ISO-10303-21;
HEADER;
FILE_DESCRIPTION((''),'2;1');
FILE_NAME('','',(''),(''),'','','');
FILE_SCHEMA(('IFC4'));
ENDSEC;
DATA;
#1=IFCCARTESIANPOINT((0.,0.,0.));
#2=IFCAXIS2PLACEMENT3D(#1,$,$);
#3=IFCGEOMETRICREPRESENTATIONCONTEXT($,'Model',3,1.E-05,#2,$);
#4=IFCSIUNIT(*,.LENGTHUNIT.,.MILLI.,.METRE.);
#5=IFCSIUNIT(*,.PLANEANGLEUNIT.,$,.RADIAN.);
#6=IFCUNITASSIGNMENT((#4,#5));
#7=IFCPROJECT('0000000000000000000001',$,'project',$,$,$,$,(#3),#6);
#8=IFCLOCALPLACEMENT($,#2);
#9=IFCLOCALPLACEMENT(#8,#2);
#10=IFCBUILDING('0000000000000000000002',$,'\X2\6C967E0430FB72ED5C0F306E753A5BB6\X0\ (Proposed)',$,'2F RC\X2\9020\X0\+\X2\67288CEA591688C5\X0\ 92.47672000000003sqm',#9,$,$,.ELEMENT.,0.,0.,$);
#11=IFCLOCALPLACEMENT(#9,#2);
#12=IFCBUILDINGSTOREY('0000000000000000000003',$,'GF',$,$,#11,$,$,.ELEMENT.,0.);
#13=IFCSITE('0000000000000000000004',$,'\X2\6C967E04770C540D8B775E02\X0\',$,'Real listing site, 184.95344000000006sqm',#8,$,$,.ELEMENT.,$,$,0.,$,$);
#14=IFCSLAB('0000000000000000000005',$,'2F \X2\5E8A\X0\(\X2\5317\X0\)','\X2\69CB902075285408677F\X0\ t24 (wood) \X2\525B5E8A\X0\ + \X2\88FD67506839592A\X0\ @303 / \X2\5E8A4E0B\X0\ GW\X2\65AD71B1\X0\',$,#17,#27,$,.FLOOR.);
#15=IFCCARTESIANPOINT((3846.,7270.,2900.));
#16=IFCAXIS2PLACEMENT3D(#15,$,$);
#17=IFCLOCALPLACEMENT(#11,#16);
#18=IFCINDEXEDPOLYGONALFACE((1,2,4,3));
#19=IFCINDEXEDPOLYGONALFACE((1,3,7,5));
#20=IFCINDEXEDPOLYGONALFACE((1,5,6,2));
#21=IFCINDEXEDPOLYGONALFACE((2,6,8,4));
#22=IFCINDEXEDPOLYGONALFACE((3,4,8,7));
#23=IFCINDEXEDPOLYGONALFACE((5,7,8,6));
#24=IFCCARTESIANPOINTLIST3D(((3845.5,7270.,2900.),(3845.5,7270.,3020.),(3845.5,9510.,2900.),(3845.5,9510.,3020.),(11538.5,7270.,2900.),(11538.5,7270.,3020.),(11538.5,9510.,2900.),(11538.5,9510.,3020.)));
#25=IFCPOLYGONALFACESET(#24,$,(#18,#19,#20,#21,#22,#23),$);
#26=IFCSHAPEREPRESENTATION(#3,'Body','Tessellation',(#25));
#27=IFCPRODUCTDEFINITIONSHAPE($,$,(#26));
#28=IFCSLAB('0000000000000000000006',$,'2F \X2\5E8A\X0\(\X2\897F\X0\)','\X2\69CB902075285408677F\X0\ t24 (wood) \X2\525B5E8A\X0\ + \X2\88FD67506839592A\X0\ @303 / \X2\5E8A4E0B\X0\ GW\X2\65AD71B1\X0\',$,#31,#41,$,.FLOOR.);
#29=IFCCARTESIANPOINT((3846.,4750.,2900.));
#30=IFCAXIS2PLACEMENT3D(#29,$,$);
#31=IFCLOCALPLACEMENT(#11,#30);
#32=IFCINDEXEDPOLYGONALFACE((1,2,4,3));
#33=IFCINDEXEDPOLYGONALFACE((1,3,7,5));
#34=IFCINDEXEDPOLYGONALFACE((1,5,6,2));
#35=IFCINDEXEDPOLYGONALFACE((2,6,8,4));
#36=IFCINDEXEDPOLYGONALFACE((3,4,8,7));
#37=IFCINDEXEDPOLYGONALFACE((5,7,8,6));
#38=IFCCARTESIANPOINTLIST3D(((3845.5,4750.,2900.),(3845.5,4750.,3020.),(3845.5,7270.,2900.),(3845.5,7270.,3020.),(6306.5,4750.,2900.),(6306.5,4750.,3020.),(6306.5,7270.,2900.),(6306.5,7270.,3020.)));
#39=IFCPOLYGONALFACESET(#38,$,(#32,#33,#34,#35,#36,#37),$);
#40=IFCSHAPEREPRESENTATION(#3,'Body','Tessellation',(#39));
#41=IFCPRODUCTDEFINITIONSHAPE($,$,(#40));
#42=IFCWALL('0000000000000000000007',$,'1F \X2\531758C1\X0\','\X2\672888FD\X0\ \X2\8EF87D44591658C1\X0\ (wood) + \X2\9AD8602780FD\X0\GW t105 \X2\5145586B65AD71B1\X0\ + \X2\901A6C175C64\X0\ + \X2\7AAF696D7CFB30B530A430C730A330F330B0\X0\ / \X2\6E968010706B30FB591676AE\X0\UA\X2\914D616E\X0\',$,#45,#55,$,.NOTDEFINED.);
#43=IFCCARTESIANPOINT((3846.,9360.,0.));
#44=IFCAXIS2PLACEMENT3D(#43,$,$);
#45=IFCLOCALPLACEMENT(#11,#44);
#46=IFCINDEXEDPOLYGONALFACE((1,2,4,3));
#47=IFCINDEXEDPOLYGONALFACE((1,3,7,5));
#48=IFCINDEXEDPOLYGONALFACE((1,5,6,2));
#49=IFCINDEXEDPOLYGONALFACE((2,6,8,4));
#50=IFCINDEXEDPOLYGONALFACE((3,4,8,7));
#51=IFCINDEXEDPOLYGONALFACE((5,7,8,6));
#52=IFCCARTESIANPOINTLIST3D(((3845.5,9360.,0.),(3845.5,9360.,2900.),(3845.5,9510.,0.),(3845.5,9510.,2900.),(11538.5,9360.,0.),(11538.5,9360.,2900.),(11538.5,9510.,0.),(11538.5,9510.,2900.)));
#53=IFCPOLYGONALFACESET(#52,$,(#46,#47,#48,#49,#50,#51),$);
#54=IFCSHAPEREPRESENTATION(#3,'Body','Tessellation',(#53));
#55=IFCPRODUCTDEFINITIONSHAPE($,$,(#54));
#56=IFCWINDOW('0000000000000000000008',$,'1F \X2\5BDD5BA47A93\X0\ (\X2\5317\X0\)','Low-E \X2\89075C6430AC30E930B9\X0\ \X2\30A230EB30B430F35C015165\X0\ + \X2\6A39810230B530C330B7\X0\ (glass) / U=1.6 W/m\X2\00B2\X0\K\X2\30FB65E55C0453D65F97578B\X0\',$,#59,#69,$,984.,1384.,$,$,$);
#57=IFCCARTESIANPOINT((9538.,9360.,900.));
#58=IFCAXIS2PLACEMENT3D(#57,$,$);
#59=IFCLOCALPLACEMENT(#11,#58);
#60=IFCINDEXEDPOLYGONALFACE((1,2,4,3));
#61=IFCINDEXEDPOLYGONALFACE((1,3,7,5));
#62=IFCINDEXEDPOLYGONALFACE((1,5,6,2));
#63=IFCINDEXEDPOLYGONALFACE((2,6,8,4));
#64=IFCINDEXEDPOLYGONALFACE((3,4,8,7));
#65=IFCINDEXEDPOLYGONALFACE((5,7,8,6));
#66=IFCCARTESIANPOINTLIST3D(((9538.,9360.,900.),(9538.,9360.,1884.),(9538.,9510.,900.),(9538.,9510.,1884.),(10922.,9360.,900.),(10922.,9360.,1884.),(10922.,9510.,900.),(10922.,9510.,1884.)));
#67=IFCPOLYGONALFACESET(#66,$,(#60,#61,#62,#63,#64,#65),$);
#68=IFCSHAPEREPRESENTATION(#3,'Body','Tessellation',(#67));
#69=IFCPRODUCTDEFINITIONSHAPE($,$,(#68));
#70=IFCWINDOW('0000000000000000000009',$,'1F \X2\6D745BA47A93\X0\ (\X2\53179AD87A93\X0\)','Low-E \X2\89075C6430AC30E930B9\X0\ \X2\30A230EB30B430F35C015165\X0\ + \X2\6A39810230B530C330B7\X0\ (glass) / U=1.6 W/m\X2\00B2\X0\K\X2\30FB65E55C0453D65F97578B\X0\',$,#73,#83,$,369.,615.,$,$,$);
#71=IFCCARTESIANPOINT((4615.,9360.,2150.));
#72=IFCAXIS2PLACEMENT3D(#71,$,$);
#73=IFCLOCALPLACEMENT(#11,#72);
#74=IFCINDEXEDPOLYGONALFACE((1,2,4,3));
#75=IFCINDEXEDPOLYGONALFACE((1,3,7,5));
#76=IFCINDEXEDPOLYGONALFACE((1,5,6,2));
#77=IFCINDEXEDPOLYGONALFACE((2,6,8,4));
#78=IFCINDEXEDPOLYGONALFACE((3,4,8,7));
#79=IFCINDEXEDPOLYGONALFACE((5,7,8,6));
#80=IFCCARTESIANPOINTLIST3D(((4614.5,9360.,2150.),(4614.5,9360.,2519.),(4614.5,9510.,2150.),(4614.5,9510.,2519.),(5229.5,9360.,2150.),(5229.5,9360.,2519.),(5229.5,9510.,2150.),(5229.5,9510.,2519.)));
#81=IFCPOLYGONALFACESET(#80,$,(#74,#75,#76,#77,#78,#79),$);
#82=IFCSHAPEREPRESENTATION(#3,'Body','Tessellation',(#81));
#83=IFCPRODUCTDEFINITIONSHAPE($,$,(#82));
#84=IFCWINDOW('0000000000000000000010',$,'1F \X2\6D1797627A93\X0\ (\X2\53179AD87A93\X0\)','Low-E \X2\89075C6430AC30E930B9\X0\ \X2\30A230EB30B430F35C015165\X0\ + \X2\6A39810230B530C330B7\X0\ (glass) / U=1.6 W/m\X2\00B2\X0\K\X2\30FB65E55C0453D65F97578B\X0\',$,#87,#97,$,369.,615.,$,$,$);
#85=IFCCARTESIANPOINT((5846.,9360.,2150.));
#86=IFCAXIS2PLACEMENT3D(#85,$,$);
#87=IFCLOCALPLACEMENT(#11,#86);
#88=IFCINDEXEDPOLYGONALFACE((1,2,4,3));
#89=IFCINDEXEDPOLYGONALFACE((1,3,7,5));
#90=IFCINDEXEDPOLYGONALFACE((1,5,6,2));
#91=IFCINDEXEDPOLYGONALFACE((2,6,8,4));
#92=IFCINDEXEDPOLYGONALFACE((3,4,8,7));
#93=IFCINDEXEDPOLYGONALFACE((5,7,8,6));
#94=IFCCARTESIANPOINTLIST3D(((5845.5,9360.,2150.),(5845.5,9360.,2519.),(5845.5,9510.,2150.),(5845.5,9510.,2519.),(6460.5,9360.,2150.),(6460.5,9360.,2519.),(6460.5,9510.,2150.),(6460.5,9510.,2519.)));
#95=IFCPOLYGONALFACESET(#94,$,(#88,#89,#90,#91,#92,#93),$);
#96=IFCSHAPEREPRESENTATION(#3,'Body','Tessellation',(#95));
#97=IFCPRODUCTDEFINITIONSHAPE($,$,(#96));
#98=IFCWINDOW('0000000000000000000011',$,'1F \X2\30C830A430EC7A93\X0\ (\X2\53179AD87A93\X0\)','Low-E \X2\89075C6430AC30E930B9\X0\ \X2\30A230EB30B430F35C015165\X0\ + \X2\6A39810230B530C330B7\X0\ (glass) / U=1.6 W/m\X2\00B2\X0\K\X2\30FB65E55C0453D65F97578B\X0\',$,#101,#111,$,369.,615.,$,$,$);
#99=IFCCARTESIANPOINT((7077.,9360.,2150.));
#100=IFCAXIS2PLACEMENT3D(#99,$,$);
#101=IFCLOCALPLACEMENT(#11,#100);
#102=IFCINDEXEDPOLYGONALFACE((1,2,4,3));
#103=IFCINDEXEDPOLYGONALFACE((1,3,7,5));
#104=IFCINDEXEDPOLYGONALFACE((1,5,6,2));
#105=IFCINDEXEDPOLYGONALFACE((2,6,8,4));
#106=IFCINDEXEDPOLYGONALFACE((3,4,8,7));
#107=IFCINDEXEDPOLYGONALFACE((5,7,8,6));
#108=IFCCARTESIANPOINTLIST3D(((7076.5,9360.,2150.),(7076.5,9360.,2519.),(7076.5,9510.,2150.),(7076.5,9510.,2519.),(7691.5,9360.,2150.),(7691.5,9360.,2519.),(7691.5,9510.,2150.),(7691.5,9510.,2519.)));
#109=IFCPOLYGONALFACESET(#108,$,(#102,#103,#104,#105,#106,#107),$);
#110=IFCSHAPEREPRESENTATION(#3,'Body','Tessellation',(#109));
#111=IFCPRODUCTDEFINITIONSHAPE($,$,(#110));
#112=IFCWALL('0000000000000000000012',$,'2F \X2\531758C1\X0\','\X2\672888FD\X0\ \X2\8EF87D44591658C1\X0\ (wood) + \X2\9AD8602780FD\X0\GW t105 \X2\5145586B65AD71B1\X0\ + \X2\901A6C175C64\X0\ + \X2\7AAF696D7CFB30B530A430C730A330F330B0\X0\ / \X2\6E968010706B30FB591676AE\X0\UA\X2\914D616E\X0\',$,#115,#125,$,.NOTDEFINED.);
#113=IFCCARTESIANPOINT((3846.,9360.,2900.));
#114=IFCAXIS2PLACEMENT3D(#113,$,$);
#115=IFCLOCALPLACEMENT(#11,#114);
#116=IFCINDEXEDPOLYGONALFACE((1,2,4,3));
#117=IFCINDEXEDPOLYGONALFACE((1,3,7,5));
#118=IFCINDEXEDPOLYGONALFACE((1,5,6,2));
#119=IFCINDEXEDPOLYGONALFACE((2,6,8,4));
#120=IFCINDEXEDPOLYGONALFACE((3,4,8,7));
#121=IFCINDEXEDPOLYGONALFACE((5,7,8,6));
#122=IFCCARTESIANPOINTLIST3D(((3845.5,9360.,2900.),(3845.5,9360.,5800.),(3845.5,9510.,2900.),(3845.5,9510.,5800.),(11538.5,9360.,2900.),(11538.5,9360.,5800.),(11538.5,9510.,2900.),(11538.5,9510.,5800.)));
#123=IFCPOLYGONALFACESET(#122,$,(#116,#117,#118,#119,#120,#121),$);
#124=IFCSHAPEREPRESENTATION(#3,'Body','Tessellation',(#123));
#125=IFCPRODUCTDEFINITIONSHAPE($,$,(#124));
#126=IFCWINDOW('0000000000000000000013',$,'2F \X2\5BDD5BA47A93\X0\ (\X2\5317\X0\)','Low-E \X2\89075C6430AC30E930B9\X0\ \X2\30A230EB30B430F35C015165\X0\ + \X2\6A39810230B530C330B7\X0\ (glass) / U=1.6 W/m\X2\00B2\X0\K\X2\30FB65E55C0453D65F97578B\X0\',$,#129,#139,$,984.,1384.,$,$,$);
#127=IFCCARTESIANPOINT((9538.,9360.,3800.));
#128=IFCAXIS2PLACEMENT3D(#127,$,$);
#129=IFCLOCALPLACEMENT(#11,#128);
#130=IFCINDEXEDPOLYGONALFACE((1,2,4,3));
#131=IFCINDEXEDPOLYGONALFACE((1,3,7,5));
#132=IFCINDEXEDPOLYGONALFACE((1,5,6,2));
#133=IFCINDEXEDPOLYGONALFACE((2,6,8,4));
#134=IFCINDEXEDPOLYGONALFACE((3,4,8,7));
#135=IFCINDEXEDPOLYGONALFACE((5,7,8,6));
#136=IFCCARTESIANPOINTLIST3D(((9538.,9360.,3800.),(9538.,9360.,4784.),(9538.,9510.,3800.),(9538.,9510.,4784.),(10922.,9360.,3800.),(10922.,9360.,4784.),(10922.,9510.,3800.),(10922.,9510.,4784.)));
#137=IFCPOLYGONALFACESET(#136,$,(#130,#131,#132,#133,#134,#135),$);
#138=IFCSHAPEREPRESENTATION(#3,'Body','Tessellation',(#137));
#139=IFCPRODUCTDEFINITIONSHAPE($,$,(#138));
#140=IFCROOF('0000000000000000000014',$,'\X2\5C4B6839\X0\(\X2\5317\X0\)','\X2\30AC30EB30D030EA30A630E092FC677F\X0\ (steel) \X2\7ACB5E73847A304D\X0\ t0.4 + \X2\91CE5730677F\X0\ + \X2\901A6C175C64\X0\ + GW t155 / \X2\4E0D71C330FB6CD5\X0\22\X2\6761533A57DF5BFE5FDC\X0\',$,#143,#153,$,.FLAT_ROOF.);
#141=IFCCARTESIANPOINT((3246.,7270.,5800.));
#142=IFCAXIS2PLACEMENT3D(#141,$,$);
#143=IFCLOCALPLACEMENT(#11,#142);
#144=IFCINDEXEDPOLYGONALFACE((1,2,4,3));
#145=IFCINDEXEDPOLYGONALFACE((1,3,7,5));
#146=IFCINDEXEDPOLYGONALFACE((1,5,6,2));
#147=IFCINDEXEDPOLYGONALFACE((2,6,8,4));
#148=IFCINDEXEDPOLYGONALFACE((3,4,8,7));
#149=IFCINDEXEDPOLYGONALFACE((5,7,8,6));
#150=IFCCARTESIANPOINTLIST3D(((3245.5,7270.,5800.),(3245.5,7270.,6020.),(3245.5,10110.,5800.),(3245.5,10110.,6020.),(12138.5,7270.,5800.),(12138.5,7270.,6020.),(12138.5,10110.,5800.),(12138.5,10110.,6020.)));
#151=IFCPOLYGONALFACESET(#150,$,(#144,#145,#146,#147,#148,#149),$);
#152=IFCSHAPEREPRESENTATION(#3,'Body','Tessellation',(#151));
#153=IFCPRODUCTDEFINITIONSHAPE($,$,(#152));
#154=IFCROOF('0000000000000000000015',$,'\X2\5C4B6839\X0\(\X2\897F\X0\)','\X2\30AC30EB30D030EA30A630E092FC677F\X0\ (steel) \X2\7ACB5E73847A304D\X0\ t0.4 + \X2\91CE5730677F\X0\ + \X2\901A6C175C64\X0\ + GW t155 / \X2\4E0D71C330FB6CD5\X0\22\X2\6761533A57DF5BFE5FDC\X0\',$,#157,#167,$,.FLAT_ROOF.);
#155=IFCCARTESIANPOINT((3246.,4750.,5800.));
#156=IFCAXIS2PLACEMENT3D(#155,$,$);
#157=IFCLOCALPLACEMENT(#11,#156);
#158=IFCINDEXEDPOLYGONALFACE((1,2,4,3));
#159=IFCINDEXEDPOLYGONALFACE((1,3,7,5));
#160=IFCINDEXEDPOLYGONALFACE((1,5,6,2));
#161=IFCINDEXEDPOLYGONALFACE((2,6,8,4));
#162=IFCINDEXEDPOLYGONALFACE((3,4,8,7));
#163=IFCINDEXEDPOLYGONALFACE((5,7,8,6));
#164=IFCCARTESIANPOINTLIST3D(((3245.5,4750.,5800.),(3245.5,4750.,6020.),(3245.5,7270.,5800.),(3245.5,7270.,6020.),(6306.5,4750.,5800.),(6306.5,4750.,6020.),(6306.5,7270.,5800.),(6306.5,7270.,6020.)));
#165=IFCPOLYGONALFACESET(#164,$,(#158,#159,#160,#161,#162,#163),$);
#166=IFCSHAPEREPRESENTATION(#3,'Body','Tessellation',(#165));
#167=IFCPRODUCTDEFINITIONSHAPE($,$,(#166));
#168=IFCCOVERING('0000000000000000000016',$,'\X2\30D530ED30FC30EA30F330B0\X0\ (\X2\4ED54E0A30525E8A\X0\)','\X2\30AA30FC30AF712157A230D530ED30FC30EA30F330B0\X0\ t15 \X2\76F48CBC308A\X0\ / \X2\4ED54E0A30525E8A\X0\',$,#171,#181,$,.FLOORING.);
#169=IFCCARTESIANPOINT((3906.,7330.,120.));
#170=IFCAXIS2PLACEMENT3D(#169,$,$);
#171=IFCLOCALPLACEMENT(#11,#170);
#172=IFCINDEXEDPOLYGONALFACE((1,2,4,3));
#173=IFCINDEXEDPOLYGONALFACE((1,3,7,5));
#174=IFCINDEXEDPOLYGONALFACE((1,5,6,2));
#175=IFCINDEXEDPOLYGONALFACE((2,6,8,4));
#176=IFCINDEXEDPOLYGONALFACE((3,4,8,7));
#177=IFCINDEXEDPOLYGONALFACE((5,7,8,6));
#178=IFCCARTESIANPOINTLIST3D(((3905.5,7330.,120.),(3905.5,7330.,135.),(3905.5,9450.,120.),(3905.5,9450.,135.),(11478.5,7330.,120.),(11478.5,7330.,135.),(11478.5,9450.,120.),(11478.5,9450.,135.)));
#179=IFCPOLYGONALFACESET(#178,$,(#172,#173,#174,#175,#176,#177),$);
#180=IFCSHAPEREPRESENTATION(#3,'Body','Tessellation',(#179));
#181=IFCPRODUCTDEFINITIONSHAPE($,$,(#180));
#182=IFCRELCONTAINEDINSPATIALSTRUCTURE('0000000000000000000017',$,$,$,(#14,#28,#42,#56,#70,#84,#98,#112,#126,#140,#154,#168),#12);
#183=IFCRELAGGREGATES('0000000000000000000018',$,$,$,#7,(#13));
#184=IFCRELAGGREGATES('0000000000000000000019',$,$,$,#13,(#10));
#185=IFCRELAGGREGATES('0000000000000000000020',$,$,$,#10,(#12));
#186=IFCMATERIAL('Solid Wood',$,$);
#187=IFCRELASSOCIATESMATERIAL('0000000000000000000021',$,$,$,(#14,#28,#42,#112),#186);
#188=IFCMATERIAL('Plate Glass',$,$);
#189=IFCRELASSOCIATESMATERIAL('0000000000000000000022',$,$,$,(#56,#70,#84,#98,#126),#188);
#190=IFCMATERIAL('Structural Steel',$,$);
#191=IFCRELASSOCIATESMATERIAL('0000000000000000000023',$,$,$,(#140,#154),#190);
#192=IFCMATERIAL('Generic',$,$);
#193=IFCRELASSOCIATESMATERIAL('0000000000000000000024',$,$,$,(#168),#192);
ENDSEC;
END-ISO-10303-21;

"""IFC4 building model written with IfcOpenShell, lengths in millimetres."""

from ifc_helpers import new_model, si_unit, frame, frame_2d, origin, place, context, project, spatial, rectangle, extrude, material, element, fill, save


model = new_model("IFC4")

# Units and contexts
model_context = context("Model", 3, precision=1e-05, world=origin())
ifc_project = project(units=[si_unit("LENGTHUNIT", "METRE", prefix="MILLI"), si_unit("PLANEANGLEUNIT", "RADIAN")], contexts=[model_context])

# Site, building, storey
site_placement = place(None, origin())
site = spatial("IfcSite", under=ifc_project, at=site_placement, Name="沖縄県名護市", ObjectType="Real listing site, 184.95344000000006sqm", CompositionType="ELEMENT", RefElevation=0.0)
building_placement = place(site_placement, origin())
building = spatial("IfcBuilding", under=site, at=building_placement, Name="沖縄・狭小の町家 (Proposed)", ObjectType="2F RC造+木質外装 92.47672000000003sqm", CompositionType="ELEMENT", ElevationOfRefHeight=0.0, ElevationOfTerrain=0.0)
storey_placement = place(building_placement, origin())
storey = spatial("IfcBuildingStorey", under=building, at=storey_placement, Name="GF", CompositionType="ELEMENT", Elevation=0.0)

# Slabs
ifc_material_1 = material(Name="Solid Wood")
slab_1_placement = place(storey_placement, frame((3846.0, 7270.0, 2900.0)))
element("IfcSlab", 1, at=slab_1_placement, inside=storey, material=ifc_material_1, Name="2F 床(北)", Description="構造用合板 t24 (wood) 剛床 + 製材根太 @303 / 床下 GW断熱", PredefinedType="FLOOR", context=model_context, shape_type="SweptSolid", body=[
    extrude(rectangle(XDim=7693.0, YDim=2240.0, at=frame_2d((3846.0, 1120.0))), frame((3846.0, 7270.0, 2900.0)), (0.0, 0.0, 1.0), 120.0),
])
slab_2_placement = place(storey_placement, frame((3846.0, 4750.0, 2900.0)))
element("IfcSlab", 2, at=slab_2_placement, inside=storey, material=ifc_material_1, Name="2F 床(西)", Description="構造用合板 t24 (wood) 剛床 + 製材根太 @303 / 床下 GW断熱", PredefinedType="FLOOR", context=model_context, shape_type="SweptSolid", body=[
    extrude(rectangle(XDim=2461.0, YDim=2520.0, at=frame_2d((1230.0, 1260.0))), frame((3846.0, 4750.0, 2900.0)), (0.0, 0.0, 1.0), 120.0),
])

# Wall, openings, windows
wall_1_placement = place(storey_placement, frame((3846.0, 9360.0, 0.0)))
wall_1 = element("IfcWall", 3, at=wall_1_placement, inside=storey, material=ifc_material_1, Name="1F 北壁", Description="木製 軸組外壁 (wood) + 高性能GW t105 充填断熱 + 通気層 + 窯業系サイディング / 準耐火・外皮UA配慮", PredefinedType="NOTDEFINED", context=model_context, shape_type="SweptSolid", body=[
    extrude(rectangle(XDim=7693.0, YDim=150.0, at=frame_2d((3846.0, 75.0))), frame((3846.0, 9360.0, 0.0)), (0.0, 0.0, 1.0), 2900.0),
])
opening_1_placement = place(storey_placement, frame((9538.0, 9360.0, 900.0)))
opening_1 = element("IfcOpeningElement", 4, at=opening_1_placement, cuts=wall_1, PredefinedType="NOTDEFINED", context=model_context, shape_type="SweptSolid", body=[
    extrude(rectangle(XDim=1384.0, YDim=150.0, at=frame_2d((692.0, 75.0))), frame((9538.0, 9360.0, 900.0)), (0.0, 0.0, 1.0), 984.0),
])
opening_2_placement = place(storey_placement, frame((4615.0, 9360.0, 2150.0)))
opening_2 = element("IfcOpeningElement", 5, at=opening_2_placement, cuts=wall_1, PredefinedType="NOTDEFINED", context=model_context, shape_type="SweptSolid", body=[
    extrude(rectangle(XDim=615.0, YDim=150.0, at=frame_2d((307.0, 75.0))), frame((4615.0, 9360.0, 2150.0)), (0.0, 0.0, 1.0), 369.0),
])
opening_3_placement = place(storey_placement, frame((5846.0, 9360.0, 2150.0)))
opening_3 = element("IfcOpeningElement", 6, at=opening_3_placement, cuts=wall_1, PredefinedType="NOTDEFINED", context=model_context, shape_type="SweptSolid", body=[
    extrude(rectangle(XDim=615.0, YDim=150.0, at=frame_2d((307.0, 75.0))), frame((5846.0, 9360.0, 2150.0)), (0.0, 0.0, 1.0), 369.0),
])
opening_4_placement = place(storey_placement, frame((7077.0, 9360.0, 2150.0)))
opening_4 = element("IfcOpeningElement", 7, at=opening_4_placement, cuts=wall_1, PredefinedType="NOTDEFINED", context=model_context, shape_type="SweptSolid", body=[
    extrude(rectangle(XDim=615.0, YDim=150.0, at=frame_2d((307.0, 75.0))), frame((7077.0, 9360.0, 2150.0)), (0.0, 0.0, 1.0), 369.0),
])
ifc_material_2 = material(Name="Plate Glass")
window_1_placement = place(storey_placement, frame((9538.0, 9360.0, 900.0)))
window_1 = element("IfcWindow", 8, at=window_1_placement, inside=storey, material=ifc_material_2, Name="1F 寝室窓 (北)", Description="Low-E 複層ガラス アルゴン封入 + 樹脂サッシ (glass) / U=1.6 W/m²K・日射取得型", OverallHeight=984.0, OverallWidth=1384.0, context=model_context, shape_type="SweptSolid", body=[
    extrude(rectangle(XDim=1384.0, YDim=150.0, at=frame_2d((692.0, 75.0))), frame((9538.0, 9360.0, 900.0)), (0.0, 0.0, 1.0), 984.0),
])
fill(opening_1, window_1)
window_2_placement = place(storey_placement, frame((4615.0, 9360.0, 2150.0)))
window_2 = element("IfcWindow", 9, at=window_2_placement, inside=storey, material=ifc_material_2, Name="1F 浴室窓 (北高窓)", Description="Low-E 複層ガラス アルゴン封入 + 樹脂サッシ (glass) / U=1.6 W/m²K・日射取得型", OverallHeight=369.0, OverallWidth=615.0, context=model_context, shape_type="SweptSolid", body=[
    extrude(rectangle(XDim=615.0, YDim=150.0, at=frame_2d((307.0, 75.0))), frame((4615.0, 9360.0, 2150.0)), (0.0, 0.0, 1.0), 369.0),
])
fill(opening_2, window_2)
window_3_placement = place(storey_placement, frame((5846.0, 9360.0, 2150.0)))
window_3 = element("IfcWindow", 10, at=window_3_placement, inside=storey, material=ifc_material_2, Name="1F 洗面窓 (北高窓)", Description="Low-E 複層ガラス アルゴン封入 + 樹脂サッシ (glass) / U=1.6 W/m²K・日射取得型", OverallHeight=369.0, OverallWidth=615.0, context=model_context, shape_type="SweptSolid", body=[
    extrude(rectangle(XDim=615.0, YDim=150.0, at=frame_2d((307.0, 75.0))), frame((5846.0, 9360.0, 2150.0)), (0.0, 0.0, 1.0), 369.0),
])
fill(opening_3, window_3)
window_4_placement = place(storey_placement, frame((7077.0, 9360.0, 2150.0)))
window_4 = element("IfcWindow", 11, at=window_4_placement, inside=storey, material=ifc_material_2, Name="1F トイレ窓 (北高窓)", Description="Low-E 複層ガラス アルゴン封入 + 樹脂サッシ (glass) / U=1.6 W/m²K・日射取得型", OverallHeight=369.0, OverallWidth=615.0, context=model_context, shape_type="SweptSolid", body=[
    extrude(rectangle(XDim=615.0, YDim=150.0, at=frame_2d((307.0, 75.0))), frame((7077.0, 9360.0, 2150.0)), (0.0, 0.0, 1.0), 369.0),
])
fill(opening_4, window_4)

# Wall, opening, window
wall_2_placement = place(storey_placement, frame((3846.0, 9360.0, 2900.0)))
wall_2 = element("IfcWall", 12, at=wall_2_placement, inside=storey, material=ifc_material_1, Name="2F 北壁", Description="木製 軸組外壁 (wood) + 高性能GW t105 充填断熱 + 通気層 + 窯業系サイディング / 準耐火・外皮UA配慮", PredefinedType="NOTDEFINED", context=model_context, shape_type="SweptSolid", body=[
    extrude(rectangle(XDim=7693.0, YDim=150.0, at=frame_2d((3846.0, 75.0))), frame((3846.0, 9360.0, 2900.0)), (0.0, 0.0, 1.0), 2900.0),
])
opening_5_placement = place(storey_placement, frame((9538.0, 9360.0, 3800.0)))
opening_5 = element("IfcOpeningElement", 13, at=opening_5_placement, cuts=wall_2, PredefinedType="NOTDEFINED", context=model_context, shape_type="SweptSolid", body=[
    extrude(rectangle(XDim=1384.0, YDim=150.0, at=frame_2d((692.0, 75.0))), frame((9538.0, 9360.0, 3800.0)), (0.0, 0.0, 1.0), 984.0),
])
window_5_placement = place(storey_placement, frame((9538.0, 9360.0, 3800.0)))
window_5 = element("IfcWindow", 14, at=window_5_placement, inside=storey, material=ifc_material_2, Name="2F 寝室窓 (北)", Description="Low-E 複層ガラス アルゴン封入 + 樹脂サッシ (glass) / U=1.6 W/m²K・日射取得型", OverallHeight=984.0, OverallWidth=1384.0, context=model_context, shape_type="SweptSolid", body=[
    extrude(rectangle(XDim=1384.0, YDim=150.0, at=frame_2d((692.0, 75.0))), frame((9538.0, 9360.0, 3800.0)), (0.0, 0.0, 1.0), 984.0),
])
fill(opening_5, window_5)

# Roofs
ifc_material_3 = material(Name="Structural Steel")
for number, where, name in (
    (15, (3246.0, 7270.0, 5800.0), "屋根(北)"),
):
    element("IfcRoof", number, at=place(storey_placement, frame(where)), inside=storey, material=ifc_material_3, Name=name, Description="ガルバリウム鋼板 (steel) 立平葺き t0.4 + 野地板 + 通気層 + GW t155 / 不燃・法22条区域対応", PredefinedType="FLAT_ROOF", context=model_context, shape_type="SweptSolid", body=[
        extrude(rectangle(XDim=8893.0, YDim=2840.0, at=frame_2d((4446.0, 1420.0))), frame((3246.0, 7270.0, 5800.0)), (0.0, 0.0, 1.0), 220.0),
    ])
roof_placement = place(storey_placement, frame((3246.0, 4750.0, 5800.0)))
element("IfcRoof", 16, at=roof_placement, inside=storey, material=ifc_material_3, Name="屋根(西)", Description="ガルバリウム鋼板 (steel) 立平葺き t0.4 + 野地板 + 通気層 + GW t155 / 不燃・法22条区域対応", PredefinedType="FLAT_ROOF", context=model_context, shape_type="SweptSolid", body=[
    extrude(rectangle(XDim=3061.0, YDim=2520.0, at=frame_2d((1530.0, 1260.0))), frame((3246.0, 4750.0, 5800.0)), (0.0, 0.0, 1.0), 220.0),
])

# Covering
ifc_material_4 = material(Name="Generic")
covering_1_placement = place(storey_placement, frame((3906.0, 7330.0, 120.0)))
element("IfcCovering", 17, at=covering_1_placement, inside=storey, material=ifc_material_4, Name="フローリング (仕上げ床)", Description="オーク無垢フローリング t15 直貼り / 仕上げ床", PredefinedType="FLOORING", context=model_context, shape_type="SweptSolid", body=[
    extrude(rectangle(XDim=7573.0, YDim=2120.0, at=frame_2d((3786.0, 1060.0))), frame((3906.0, 7330.0, 120.0)), (0.0, 0.0, 1.0), 15.0),
])

save(model, "model.ifc")
